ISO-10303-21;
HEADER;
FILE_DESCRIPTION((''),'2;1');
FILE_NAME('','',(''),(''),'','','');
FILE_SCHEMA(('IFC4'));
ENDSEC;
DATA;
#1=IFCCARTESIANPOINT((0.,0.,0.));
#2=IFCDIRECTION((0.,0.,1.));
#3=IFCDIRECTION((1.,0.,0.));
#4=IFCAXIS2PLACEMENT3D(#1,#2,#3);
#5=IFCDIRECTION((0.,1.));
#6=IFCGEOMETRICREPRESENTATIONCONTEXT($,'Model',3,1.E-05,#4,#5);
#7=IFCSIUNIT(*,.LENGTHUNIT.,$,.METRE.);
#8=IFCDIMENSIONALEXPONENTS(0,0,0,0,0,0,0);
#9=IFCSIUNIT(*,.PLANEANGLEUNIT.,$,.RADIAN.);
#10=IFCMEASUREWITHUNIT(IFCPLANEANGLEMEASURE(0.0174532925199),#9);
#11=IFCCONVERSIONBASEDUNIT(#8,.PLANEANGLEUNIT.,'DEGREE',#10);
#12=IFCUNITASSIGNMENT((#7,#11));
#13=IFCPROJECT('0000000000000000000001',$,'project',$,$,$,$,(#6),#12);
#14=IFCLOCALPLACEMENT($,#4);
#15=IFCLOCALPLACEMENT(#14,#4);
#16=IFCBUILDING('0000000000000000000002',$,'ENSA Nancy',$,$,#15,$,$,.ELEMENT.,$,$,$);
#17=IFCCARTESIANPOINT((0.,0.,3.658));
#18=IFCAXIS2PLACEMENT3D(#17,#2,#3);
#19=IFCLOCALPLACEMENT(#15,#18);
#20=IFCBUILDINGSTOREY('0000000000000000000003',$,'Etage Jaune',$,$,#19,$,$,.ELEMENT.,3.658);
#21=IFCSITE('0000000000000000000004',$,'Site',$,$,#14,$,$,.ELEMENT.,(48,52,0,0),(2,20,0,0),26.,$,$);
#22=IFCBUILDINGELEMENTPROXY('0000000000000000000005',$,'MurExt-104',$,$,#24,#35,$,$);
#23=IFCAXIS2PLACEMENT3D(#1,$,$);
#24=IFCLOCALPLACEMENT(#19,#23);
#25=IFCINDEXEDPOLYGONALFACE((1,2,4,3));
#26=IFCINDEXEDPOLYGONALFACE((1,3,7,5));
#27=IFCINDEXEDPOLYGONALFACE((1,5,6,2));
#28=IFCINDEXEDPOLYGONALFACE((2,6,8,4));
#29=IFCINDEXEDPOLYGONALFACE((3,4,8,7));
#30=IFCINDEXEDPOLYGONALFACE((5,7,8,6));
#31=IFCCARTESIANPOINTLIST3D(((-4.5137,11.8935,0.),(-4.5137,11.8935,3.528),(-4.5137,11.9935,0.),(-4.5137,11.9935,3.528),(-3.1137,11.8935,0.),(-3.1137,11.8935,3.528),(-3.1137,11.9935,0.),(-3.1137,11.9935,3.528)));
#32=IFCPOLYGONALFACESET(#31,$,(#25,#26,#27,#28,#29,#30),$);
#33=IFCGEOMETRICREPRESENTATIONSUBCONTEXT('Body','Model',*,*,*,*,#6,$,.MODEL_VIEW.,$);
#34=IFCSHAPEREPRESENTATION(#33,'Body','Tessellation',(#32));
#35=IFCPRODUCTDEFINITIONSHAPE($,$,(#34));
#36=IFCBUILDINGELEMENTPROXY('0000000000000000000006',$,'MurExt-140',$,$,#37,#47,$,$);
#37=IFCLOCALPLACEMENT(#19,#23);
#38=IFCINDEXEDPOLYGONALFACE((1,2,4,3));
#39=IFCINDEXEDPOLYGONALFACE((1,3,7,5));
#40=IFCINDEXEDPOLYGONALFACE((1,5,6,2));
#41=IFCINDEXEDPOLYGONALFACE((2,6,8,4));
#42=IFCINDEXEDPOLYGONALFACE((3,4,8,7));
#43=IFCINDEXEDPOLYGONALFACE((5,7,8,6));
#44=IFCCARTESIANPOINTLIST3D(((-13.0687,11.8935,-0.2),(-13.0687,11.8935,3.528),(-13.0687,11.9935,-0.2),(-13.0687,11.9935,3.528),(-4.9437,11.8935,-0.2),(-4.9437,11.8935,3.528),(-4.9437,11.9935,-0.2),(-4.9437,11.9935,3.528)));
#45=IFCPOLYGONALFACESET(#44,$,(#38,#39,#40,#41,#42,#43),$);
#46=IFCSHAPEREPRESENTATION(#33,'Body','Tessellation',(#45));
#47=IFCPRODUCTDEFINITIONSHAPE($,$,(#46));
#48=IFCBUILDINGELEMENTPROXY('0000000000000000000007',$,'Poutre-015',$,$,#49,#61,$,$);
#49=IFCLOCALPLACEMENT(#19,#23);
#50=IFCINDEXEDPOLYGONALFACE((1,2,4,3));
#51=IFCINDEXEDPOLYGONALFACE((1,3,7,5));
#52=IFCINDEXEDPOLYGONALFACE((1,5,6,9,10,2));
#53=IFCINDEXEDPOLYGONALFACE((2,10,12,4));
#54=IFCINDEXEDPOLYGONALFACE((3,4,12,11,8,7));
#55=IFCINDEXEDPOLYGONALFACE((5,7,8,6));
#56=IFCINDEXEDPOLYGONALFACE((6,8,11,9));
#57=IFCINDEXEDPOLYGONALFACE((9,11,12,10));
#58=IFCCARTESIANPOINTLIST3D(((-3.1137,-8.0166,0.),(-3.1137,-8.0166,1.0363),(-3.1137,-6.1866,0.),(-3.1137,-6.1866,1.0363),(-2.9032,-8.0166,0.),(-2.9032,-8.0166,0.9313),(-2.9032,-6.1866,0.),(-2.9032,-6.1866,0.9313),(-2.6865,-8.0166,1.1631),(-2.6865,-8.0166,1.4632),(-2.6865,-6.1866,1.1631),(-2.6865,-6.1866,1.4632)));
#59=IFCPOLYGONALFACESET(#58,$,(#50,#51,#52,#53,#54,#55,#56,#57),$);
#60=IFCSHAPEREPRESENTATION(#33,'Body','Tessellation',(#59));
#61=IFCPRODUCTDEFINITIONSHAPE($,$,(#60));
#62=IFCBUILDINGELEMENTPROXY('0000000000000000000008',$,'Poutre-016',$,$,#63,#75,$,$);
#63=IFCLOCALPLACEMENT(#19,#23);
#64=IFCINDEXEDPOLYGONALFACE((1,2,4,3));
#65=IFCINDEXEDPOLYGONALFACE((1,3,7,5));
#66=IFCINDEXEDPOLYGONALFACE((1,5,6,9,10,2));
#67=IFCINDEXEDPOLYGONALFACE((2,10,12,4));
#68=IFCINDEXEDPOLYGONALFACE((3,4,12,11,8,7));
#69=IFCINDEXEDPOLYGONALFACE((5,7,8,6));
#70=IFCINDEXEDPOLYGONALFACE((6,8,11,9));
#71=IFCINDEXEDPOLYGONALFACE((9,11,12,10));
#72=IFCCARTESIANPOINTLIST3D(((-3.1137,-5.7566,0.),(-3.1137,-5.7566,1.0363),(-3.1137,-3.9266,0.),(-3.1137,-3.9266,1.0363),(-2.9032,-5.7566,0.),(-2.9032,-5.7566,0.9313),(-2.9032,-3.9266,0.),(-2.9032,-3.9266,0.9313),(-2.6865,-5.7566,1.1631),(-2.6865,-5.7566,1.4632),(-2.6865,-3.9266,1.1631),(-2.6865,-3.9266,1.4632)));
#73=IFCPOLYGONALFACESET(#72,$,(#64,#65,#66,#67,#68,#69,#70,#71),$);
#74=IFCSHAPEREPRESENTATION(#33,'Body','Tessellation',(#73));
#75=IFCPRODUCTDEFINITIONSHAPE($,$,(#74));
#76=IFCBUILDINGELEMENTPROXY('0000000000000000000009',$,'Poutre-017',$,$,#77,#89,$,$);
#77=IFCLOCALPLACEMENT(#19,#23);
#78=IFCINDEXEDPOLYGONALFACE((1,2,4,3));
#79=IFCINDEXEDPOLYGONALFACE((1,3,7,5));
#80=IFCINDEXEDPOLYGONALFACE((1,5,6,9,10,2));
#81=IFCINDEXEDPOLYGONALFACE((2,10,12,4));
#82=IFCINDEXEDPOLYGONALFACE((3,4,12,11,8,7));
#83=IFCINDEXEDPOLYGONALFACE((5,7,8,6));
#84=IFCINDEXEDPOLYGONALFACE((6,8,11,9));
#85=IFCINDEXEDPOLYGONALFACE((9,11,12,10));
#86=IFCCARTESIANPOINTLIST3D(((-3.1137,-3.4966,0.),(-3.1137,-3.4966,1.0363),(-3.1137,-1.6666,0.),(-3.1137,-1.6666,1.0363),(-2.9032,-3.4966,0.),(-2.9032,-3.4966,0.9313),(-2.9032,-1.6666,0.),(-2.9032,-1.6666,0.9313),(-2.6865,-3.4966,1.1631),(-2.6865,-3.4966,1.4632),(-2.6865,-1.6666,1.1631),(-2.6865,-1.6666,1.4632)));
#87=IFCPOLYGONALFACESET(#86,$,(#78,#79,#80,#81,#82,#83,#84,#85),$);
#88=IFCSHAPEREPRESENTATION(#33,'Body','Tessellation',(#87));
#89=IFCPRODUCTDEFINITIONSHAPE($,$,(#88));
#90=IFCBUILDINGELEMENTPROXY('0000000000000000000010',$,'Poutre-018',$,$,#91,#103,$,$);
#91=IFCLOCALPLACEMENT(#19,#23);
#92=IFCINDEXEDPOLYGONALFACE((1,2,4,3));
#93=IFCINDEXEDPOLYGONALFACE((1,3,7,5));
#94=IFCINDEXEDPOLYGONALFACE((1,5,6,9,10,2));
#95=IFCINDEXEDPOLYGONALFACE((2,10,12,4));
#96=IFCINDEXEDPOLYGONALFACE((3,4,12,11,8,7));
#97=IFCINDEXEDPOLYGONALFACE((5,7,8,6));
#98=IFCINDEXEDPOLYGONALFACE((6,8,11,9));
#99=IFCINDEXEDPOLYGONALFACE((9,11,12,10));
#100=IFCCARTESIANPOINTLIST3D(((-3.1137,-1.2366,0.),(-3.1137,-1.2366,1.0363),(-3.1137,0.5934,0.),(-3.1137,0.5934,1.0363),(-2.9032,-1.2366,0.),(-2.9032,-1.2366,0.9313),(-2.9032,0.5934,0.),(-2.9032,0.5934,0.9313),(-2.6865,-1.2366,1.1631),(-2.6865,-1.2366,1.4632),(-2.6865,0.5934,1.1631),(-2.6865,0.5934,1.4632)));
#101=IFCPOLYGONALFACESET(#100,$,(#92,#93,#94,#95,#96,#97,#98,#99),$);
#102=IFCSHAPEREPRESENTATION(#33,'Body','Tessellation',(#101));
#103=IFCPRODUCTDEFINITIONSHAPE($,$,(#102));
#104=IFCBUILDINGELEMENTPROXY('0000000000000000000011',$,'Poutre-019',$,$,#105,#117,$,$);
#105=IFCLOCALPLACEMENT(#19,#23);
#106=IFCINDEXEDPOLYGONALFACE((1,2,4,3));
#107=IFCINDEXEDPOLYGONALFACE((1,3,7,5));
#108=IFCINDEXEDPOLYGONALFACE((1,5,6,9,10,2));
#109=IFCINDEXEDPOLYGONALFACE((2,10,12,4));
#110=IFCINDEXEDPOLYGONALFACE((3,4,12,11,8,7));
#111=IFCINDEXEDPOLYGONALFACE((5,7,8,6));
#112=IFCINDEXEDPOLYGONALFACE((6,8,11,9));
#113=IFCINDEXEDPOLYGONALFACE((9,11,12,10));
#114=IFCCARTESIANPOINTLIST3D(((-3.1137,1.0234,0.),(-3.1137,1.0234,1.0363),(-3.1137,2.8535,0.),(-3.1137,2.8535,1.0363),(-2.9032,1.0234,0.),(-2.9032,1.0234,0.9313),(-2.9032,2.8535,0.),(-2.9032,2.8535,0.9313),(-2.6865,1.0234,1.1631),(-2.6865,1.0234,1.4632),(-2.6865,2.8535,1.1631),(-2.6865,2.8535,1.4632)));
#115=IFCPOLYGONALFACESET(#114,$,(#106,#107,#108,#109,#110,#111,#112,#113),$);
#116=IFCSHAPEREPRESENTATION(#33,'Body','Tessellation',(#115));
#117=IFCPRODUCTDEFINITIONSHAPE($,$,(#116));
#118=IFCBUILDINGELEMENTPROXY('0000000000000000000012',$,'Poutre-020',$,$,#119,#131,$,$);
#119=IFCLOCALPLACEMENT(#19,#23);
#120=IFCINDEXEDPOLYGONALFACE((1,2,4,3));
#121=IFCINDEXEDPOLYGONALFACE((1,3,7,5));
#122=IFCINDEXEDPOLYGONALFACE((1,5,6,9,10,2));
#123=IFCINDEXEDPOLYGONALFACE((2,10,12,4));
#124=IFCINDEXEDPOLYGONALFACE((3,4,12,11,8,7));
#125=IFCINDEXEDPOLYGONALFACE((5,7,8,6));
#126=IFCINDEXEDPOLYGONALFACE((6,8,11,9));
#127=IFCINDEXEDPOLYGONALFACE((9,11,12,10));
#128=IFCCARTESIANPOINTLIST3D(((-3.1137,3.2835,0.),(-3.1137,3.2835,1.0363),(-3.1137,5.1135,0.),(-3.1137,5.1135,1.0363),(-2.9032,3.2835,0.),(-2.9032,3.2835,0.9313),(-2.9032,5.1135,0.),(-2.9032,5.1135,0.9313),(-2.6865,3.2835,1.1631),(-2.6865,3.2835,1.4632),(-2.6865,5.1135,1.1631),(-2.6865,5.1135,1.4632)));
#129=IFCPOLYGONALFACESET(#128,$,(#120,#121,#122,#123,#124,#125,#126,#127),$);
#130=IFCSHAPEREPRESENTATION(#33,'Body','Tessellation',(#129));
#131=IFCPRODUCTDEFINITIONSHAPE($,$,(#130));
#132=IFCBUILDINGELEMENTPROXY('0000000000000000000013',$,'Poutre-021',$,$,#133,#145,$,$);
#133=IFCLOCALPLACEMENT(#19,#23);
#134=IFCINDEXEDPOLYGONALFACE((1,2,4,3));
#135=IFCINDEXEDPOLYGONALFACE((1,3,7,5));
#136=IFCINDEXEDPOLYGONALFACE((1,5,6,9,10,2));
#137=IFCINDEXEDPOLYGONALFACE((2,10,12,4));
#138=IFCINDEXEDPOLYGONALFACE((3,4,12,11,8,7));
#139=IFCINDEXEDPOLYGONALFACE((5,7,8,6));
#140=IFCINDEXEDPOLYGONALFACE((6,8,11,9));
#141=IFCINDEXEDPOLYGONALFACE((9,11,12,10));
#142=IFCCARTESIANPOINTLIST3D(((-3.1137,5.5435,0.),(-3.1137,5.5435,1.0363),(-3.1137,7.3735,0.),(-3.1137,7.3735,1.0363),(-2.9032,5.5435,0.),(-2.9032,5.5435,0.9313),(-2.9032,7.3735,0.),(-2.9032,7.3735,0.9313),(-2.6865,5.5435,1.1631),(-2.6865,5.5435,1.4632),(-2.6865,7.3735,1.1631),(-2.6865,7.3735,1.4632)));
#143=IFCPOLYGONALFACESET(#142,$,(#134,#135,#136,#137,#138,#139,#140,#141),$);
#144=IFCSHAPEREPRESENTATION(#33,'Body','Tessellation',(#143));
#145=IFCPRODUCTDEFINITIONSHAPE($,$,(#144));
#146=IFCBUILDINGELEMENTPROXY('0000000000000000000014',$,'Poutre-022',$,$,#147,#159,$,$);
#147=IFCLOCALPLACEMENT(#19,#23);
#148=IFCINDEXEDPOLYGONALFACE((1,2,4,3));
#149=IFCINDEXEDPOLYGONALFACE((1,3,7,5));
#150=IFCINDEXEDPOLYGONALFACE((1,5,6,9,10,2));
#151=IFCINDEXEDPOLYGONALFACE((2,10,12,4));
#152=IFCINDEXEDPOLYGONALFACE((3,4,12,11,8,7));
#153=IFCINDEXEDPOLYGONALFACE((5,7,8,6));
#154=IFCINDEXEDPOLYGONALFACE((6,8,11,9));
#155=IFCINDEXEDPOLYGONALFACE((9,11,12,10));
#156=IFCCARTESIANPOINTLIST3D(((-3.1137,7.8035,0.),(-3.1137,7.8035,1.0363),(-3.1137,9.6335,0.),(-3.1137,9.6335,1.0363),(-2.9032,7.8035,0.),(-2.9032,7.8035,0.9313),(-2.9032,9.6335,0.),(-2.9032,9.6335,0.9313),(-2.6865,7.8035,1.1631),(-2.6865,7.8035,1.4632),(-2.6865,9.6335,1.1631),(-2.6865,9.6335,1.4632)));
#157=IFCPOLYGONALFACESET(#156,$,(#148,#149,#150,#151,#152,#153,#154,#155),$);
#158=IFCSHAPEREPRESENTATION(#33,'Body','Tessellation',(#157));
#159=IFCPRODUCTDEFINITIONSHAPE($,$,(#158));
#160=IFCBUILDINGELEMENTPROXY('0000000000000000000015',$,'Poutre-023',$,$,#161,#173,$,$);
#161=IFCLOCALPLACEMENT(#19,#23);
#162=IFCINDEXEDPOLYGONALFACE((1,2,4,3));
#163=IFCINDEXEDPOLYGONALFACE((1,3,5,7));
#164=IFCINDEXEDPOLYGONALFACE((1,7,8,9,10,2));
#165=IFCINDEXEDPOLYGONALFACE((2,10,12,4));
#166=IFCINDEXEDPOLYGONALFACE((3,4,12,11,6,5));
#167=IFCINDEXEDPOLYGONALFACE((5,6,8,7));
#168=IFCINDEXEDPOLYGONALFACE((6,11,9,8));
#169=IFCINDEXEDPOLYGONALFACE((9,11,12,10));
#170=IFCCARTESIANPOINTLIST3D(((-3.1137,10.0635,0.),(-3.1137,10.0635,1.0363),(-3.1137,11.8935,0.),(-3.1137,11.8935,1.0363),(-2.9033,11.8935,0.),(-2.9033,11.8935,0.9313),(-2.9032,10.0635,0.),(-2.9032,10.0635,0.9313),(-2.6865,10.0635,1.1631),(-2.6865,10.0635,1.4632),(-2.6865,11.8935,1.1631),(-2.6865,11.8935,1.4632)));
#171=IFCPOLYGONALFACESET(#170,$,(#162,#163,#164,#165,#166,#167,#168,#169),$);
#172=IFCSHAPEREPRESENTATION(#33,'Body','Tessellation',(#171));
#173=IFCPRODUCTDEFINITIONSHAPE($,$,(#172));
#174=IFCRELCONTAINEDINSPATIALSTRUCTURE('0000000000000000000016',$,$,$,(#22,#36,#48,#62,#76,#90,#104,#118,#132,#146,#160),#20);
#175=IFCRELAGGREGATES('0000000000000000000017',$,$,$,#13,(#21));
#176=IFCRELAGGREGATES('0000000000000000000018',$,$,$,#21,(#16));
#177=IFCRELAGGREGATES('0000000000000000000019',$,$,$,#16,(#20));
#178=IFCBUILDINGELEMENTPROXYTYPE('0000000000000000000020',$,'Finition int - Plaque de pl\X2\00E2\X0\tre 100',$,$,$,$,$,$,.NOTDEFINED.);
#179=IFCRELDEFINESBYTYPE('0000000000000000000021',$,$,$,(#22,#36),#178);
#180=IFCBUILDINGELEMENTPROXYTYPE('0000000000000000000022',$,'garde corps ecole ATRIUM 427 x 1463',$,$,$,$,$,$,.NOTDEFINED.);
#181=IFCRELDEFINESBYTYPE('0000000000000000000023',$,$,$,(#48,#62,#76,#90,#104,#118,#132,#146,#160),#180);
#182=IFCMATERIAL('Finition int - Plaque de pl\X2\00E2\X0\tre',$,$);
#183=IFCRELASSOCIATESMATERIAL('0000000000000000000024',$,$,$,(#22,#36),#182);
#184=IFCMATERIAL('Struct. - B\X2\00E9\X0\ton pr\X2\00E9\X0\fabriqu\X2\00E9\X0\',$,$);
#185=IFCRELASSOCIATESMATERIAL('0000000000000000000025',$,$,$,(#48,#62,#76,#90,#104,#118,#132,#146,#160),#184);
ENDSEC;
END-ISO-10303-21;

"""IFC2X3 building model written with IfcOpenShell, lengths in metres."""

from ifc_helpers import new_model, entity, si_unit, converted_unit, direction, frame, origin_with_axes, place, context, subcontext, project, spatial, polyline, outline, extrude, material, type_object, element, save


model = new_model("IFC2X3")

# Units and contexts
model_context = context("Model", 3, precision=1e-05, world=origin_with_axes(), true_north=direction((0.0, 1.0)))
body_context = subcontext(model_context, "Body", "Model", "MODEL_VIEW")
ifc_project = project(units=[si_unit("LENGTHUNIT", "METRE"), converted_unit("PLANEANGLEUNIT", "DEGREE", entity("IfcPlaneAngleMeasure", 0.0174532925199), si_unit("PLANEANGLEUNIT", "RADIAN"), dimensions=[0, 0, 0, 0, 0, 0, 0])], contexts=[model_context])

# Site, building, storey
site_placement = place(None, origin_with_axes())
site = spatial("IfcSite", under=ifc_project, at=site_placement, Name="Site", CompositionType="ELEMENT", RefLatitude=(48, 52, 0, 0), RefLongitude=(2, 20, 0, 0), RefElevation=26.0)
building_placement = place(site_placement, origin_with_axes())
building = spatial("IfcBuilding", under=site, at=building_placement, Name="ENSA Nancy", CompositionType="ELEMENT")
storey_placement = place(building_placement, frame((0.0, 0.0, 3.658), z_axis=(0.0, 0.0, 1.0), x_axis=(1.0, 0.0, 0.0)))
storey = spatial("IfcBuildingStorey", under=building, at=storey_placement, Name="Etage Jaune", CompositionType="ELEMENT", Elevation=3.658)

# Building element proxies
ifc_material_1 = material(Name="Finition int - Plaque de plâtre")
building_element_proxy_type_1 = type_object("IfcBuildingElementProxyType", Name="Finition int - Plaque de plâtre 100", PredefinedType="NOTDEFINED")
proxy_1_placement = place(storey_placement, frame((-4.5137, 11.8935, 0.0), z_axis=(0.0, 0.0, 1.0), x_axis=(1.0, 0.000001, 0.0)))
element("IfcBuildingElementProxy", 1, at=proxy_1_placement, inside=storey, type_object=building_element_proxy_type_1, material=ifc_material_1, Name="MurExt-104", context=body_context, shape_type="SweptSolid", body=[
    extrude(outline(polyline([(0.0, 0.0), (1.4, 0.0), (1.4, 0.1), (0.0, 0.1), (0.0, 0.0)])), origin_with_axes(), (0.0, 0.0, 1.0), 3.528),
])
proxy_2_placement = place(storey_placement, frame((-13.0687, 11.8935, -0.2), z_axis=(0.0, 0.0, 1.0), x_axis=(1.0, 0.0, 0.0)))
element("IfcBuildingElementProxy", 2, at=proxy_2_placement, inside=storey, type_object=building_element_proxy_type_1, material=ifc_material_1, Name="MurExt-140", context=body_context, shape_type="SweptSolid", body=[
    extrude(outline(polyline([(0.0, 0.0), (8.125, 0.0), (8.125, 0.1), (0.0, 0.1), (0.0, 0.0)])), origin_with_axes(), (0.0, 0.0, 1.0), 3.728),
])
ifc_material_2 = material(Name="Struct. - Béton préfabriqué")
building_element_proxy_type_2 = type_object("IfcBuildingElementProxyType", Name="garde corps ecole ATRIUM 427 x 1463", PredefinedType="NOTDEFINED")
proxy_3_placement = place(storey_placement, frame((-3.1137, -8.0166, 0.0), z_axis=(0.0, 0.0, 1.0), x_axis=(1.0, 0.0, 0.0)))
element("IfcBuildingElementProxy", 3, at=proxy_3_placement, inside=storey, type_object=building_element_proxy_type_2, material=ifc_material_2, Name="Poutre-015", context=body_context, shape_type="SweptSolid", body=[
    extrude(outline(polyline([(0.0, 1.0363), (0.0, 0.0), (0.2105, 0.0), (0.2105, 0.9313), (0.4272, 1.1631), (0.4272, 1.4632), (0.0, 1.0363)])), frame((0.0, 1.83, 0.0), z_axis=(0.0, -1.0, 0.0), x_axis=(1.0, 0.0, 0.0)), (0.0, 0.0, 1.0), 1.83),
])
proxy_4_placement = place(storey_placement, frame((-3.1137, -5.7566, 0.0), z_axis=(0.0, 0.0, 1.0), x_axis=(1.0, 0.0, 0.0)))
element("IfcBuildingElementProxy", 4, at=proxy_4_placement, inside=storey, type_object=building_element_proxy_type_2, material=ifc_material_2, Name="Poutre-016", context=body_context, shape_type="SweptSolid", body=[
    extrude(outline(polyline([(0.0, 1.0363), (0.0, 0.0), (0.2105, 0.0), (0.2105, 0.9313), (0.4272, 1.1631), (0.4272, 1.4632), (0.0, 1.0363)])), frame((0.0, 1.83, 0.0), z_axis=(0.0, -1.0, 0.0), x_axis=(1.0, 0.0, 0.0)), (0.0, 0.0, 1.0), 1.83),
])
proxy_5_placement = place(storey_placement, frame((-3.1137, -3.4966, 0.0), z_axis=(0.0, 0.0, 1.0), x_axis=(1.0, 0.0, 0.0)))
element("IfcBuildingElementProxy", 5, at=proxy_5_placement, inside=storey, type_object=building_element_proxy_type_2, material=ifc_material_2, Name="Poutre-017", context=body_context, shape_type="SweptSolid", body=[
    extrude(outline(polyline([(0.0, 1.0363), (0.0, 0.0), (0.2105, 0.0), (0.2105, 0.9313), (0.4272, 1.1631), (0.4272, 1.4632), (0.0, 1.0363)])), frame((0.0, 1.83, 0.0), z_axis=(0.0, -1.0, 0.0), x_axis=(1.0, 0.0, 0.0)), (0.0, 0.0, 1.0), 1.83),
])
proxy_6_placement = place(storey_placement, frame((-3.1137, -1.2366, 0.0), z_axis=(0.0, 0.0, 1.0), x_axis=(1.0, 0.0, 0.0)))
element("IfcBuildingElementProxy", 6, at=proxy_6_placement, inside=storey, type_object=building_element_proxy_type_2, material=ifc_material_2, Name="Poutre-018", context=body_context, shape_type="SweptSolid", body=[
    extrude(outline(polyline([(0.0, 1.0363), (0.0, 0.0), (0.2105, 0.0), (0.2105, 0.9313), (0.4272, 1.1631), (0.4272, 1.4632), (0.0, 1.0363)])), frame((0.0, 1.83, 0.0), z_axis=(0.0, -1.0, 0.0), x_axis=(1.0, 0.0, 0.0)), (0.0, 0.0, 1.0), 1.83),
])
proxy_7_placement = place(storey_placement, frame((-3.1137, 1.0234, 0.0), z_axis=(0.0, 0.0, 1.0), x_axis=(1.0, 0.0, 0.0)))
element("IfcBuildingElementProxy", 7, at=proxy_7_placement, inside=storey, type_object=building_element_proxy_type_2, material=ifc_material_2, Name="Poutre-019", context=body_context, shape_type="SweptSolid", body=[
    extrude(outline(polyline([(0.0, 1.0363), (0.0, 0.0), (0.2105, 0.0), (0.2105, 0.9313), (0.4272, 1.1631), (0.4272, 1.4632), (0.0, 1.0363)])), frame((0.0, 1.83, 0.0), z_axis=(0.0, -1.0, 0.0), x_axis=(1.0, 0.0, 0.0)), (0.0, 0.0, 1.0), 1.83),
])
proxy_8_placement = place(storey_placement, frame((-3.1137, 3.2835, 0.0), z_axis=(0.0, 0.0, 1.0), x_axis=(1.0, 0.0, 0.0)))
element("IfcBuildingElementProxy", 8, at=proxy_8_placement, inside=storey, type_object=building_element_proxy_type_2, material=ifc_material_2, Name="Poutre-020", context=body_context, shape_type="SweptSolid", body=[
    extrude(outline(polyline([(0.0, 1.0363), (0.0, 0.0), (0.2105, 0.0), (0.2105, 0.9313), (0.4272, 1.1631), (0.4272, 1.4632), (0.0, 1.0363)])), frame((0.0, 1.83, 0.0), z_axis=(0.0, -1.0, 0.0), x_axis=(1.0, 0.0, 0.0)), (0.0, 0.0, 1.0), 1.83),
])
proxy_9_placement = place(storey_placement, frame((-3.1137, 5.5435, 0.0), z_axis=(0.0, 0.0, 1.0), x_axis=(1.0, 0.0, 0.0)))
element("IfcBuildingElementProxy", 9, at=proxy_9_placement, inside=storey, type_object=building_element_proxy_type_2, material=ifc_material_2, Name="Poutre-021", context=body_context, shape_type="SweptSolid", body=[
    extrude(outline(polyline([(0.0, 1.0363), (0.0, 0.0), (0.2105, 0.0), (0.2105, 0.9313), (0.4272, 1.1631), (0.4272, 1.4632), (0.0, 1.0363)])), frame((0.0, 1.83, 0.0), z_axis=(0.0, -1.0, 0.0), x_axis=(1.0, 0.0, 0.0)), (0.0, 0.0, 1.0), 1.83),
])
proxy_10_placement = place(storey_placement, frame((-3.1137, 7.8035, 0.0), z_axis=(0.0, 0.0, 1.0), x_axis=(1.0, 0.0, 0.0)))
element("IfcBuildingElementProxy", 10, at=proxy_10_placement, inside=storey, type_object=building_element_proxy_type_2, material=ifc_material_2, Name="Poutre-022", context=body_context, shape_type="SweptSolid", body=[
    extrude(outline(polyline([(0.0, 1.0363), (0.0, 0.0), (0.2105, 0.0), (0.2105, 0.9313), (0.4272, 1.1631), (0.4272, 1.4632), (0.0, 1.0363)])), frame((0.0, 1.83, 0.0), z_axis=(0.0, -1.0, 0.0), x_axis=(1.0, 0.0, 0.0)), (0.0, 0.0, 1.0), 1.83),
])
proxy_11_placement = place(storey_placement, frame((-3.1137, 10.0635, 0.0), z_axis=(0.0, 0.0, 1.0), x_axis=(1.0, 0.000024, 0.0)))
element("IfcBuildingElementProxy", 11, at=proxy_11_placement, inside=storey, type_object=building_element_proxy_type_2, material=ifc_material_2, Name="Poutre-023", context=body_context, shape_type="SweptSolid", body=[
    extrude(outline(polyline([(0.0, 1.0363), (0.0, 0.0), (0.2105, 0.0), (0.2105, 0.9313), (0.4272, 1.1631), (0.4272, 1.4632), (0.0, 1.0363)])), frame((0.0, 1.83, 0.0), z_axis=(0.0, -1.0, 0.0), x_axis=(1.0, 0.0, 0.0)), (0.0, 0.0, 1.0), 1.83),
])

save(model, "model.ifc")
